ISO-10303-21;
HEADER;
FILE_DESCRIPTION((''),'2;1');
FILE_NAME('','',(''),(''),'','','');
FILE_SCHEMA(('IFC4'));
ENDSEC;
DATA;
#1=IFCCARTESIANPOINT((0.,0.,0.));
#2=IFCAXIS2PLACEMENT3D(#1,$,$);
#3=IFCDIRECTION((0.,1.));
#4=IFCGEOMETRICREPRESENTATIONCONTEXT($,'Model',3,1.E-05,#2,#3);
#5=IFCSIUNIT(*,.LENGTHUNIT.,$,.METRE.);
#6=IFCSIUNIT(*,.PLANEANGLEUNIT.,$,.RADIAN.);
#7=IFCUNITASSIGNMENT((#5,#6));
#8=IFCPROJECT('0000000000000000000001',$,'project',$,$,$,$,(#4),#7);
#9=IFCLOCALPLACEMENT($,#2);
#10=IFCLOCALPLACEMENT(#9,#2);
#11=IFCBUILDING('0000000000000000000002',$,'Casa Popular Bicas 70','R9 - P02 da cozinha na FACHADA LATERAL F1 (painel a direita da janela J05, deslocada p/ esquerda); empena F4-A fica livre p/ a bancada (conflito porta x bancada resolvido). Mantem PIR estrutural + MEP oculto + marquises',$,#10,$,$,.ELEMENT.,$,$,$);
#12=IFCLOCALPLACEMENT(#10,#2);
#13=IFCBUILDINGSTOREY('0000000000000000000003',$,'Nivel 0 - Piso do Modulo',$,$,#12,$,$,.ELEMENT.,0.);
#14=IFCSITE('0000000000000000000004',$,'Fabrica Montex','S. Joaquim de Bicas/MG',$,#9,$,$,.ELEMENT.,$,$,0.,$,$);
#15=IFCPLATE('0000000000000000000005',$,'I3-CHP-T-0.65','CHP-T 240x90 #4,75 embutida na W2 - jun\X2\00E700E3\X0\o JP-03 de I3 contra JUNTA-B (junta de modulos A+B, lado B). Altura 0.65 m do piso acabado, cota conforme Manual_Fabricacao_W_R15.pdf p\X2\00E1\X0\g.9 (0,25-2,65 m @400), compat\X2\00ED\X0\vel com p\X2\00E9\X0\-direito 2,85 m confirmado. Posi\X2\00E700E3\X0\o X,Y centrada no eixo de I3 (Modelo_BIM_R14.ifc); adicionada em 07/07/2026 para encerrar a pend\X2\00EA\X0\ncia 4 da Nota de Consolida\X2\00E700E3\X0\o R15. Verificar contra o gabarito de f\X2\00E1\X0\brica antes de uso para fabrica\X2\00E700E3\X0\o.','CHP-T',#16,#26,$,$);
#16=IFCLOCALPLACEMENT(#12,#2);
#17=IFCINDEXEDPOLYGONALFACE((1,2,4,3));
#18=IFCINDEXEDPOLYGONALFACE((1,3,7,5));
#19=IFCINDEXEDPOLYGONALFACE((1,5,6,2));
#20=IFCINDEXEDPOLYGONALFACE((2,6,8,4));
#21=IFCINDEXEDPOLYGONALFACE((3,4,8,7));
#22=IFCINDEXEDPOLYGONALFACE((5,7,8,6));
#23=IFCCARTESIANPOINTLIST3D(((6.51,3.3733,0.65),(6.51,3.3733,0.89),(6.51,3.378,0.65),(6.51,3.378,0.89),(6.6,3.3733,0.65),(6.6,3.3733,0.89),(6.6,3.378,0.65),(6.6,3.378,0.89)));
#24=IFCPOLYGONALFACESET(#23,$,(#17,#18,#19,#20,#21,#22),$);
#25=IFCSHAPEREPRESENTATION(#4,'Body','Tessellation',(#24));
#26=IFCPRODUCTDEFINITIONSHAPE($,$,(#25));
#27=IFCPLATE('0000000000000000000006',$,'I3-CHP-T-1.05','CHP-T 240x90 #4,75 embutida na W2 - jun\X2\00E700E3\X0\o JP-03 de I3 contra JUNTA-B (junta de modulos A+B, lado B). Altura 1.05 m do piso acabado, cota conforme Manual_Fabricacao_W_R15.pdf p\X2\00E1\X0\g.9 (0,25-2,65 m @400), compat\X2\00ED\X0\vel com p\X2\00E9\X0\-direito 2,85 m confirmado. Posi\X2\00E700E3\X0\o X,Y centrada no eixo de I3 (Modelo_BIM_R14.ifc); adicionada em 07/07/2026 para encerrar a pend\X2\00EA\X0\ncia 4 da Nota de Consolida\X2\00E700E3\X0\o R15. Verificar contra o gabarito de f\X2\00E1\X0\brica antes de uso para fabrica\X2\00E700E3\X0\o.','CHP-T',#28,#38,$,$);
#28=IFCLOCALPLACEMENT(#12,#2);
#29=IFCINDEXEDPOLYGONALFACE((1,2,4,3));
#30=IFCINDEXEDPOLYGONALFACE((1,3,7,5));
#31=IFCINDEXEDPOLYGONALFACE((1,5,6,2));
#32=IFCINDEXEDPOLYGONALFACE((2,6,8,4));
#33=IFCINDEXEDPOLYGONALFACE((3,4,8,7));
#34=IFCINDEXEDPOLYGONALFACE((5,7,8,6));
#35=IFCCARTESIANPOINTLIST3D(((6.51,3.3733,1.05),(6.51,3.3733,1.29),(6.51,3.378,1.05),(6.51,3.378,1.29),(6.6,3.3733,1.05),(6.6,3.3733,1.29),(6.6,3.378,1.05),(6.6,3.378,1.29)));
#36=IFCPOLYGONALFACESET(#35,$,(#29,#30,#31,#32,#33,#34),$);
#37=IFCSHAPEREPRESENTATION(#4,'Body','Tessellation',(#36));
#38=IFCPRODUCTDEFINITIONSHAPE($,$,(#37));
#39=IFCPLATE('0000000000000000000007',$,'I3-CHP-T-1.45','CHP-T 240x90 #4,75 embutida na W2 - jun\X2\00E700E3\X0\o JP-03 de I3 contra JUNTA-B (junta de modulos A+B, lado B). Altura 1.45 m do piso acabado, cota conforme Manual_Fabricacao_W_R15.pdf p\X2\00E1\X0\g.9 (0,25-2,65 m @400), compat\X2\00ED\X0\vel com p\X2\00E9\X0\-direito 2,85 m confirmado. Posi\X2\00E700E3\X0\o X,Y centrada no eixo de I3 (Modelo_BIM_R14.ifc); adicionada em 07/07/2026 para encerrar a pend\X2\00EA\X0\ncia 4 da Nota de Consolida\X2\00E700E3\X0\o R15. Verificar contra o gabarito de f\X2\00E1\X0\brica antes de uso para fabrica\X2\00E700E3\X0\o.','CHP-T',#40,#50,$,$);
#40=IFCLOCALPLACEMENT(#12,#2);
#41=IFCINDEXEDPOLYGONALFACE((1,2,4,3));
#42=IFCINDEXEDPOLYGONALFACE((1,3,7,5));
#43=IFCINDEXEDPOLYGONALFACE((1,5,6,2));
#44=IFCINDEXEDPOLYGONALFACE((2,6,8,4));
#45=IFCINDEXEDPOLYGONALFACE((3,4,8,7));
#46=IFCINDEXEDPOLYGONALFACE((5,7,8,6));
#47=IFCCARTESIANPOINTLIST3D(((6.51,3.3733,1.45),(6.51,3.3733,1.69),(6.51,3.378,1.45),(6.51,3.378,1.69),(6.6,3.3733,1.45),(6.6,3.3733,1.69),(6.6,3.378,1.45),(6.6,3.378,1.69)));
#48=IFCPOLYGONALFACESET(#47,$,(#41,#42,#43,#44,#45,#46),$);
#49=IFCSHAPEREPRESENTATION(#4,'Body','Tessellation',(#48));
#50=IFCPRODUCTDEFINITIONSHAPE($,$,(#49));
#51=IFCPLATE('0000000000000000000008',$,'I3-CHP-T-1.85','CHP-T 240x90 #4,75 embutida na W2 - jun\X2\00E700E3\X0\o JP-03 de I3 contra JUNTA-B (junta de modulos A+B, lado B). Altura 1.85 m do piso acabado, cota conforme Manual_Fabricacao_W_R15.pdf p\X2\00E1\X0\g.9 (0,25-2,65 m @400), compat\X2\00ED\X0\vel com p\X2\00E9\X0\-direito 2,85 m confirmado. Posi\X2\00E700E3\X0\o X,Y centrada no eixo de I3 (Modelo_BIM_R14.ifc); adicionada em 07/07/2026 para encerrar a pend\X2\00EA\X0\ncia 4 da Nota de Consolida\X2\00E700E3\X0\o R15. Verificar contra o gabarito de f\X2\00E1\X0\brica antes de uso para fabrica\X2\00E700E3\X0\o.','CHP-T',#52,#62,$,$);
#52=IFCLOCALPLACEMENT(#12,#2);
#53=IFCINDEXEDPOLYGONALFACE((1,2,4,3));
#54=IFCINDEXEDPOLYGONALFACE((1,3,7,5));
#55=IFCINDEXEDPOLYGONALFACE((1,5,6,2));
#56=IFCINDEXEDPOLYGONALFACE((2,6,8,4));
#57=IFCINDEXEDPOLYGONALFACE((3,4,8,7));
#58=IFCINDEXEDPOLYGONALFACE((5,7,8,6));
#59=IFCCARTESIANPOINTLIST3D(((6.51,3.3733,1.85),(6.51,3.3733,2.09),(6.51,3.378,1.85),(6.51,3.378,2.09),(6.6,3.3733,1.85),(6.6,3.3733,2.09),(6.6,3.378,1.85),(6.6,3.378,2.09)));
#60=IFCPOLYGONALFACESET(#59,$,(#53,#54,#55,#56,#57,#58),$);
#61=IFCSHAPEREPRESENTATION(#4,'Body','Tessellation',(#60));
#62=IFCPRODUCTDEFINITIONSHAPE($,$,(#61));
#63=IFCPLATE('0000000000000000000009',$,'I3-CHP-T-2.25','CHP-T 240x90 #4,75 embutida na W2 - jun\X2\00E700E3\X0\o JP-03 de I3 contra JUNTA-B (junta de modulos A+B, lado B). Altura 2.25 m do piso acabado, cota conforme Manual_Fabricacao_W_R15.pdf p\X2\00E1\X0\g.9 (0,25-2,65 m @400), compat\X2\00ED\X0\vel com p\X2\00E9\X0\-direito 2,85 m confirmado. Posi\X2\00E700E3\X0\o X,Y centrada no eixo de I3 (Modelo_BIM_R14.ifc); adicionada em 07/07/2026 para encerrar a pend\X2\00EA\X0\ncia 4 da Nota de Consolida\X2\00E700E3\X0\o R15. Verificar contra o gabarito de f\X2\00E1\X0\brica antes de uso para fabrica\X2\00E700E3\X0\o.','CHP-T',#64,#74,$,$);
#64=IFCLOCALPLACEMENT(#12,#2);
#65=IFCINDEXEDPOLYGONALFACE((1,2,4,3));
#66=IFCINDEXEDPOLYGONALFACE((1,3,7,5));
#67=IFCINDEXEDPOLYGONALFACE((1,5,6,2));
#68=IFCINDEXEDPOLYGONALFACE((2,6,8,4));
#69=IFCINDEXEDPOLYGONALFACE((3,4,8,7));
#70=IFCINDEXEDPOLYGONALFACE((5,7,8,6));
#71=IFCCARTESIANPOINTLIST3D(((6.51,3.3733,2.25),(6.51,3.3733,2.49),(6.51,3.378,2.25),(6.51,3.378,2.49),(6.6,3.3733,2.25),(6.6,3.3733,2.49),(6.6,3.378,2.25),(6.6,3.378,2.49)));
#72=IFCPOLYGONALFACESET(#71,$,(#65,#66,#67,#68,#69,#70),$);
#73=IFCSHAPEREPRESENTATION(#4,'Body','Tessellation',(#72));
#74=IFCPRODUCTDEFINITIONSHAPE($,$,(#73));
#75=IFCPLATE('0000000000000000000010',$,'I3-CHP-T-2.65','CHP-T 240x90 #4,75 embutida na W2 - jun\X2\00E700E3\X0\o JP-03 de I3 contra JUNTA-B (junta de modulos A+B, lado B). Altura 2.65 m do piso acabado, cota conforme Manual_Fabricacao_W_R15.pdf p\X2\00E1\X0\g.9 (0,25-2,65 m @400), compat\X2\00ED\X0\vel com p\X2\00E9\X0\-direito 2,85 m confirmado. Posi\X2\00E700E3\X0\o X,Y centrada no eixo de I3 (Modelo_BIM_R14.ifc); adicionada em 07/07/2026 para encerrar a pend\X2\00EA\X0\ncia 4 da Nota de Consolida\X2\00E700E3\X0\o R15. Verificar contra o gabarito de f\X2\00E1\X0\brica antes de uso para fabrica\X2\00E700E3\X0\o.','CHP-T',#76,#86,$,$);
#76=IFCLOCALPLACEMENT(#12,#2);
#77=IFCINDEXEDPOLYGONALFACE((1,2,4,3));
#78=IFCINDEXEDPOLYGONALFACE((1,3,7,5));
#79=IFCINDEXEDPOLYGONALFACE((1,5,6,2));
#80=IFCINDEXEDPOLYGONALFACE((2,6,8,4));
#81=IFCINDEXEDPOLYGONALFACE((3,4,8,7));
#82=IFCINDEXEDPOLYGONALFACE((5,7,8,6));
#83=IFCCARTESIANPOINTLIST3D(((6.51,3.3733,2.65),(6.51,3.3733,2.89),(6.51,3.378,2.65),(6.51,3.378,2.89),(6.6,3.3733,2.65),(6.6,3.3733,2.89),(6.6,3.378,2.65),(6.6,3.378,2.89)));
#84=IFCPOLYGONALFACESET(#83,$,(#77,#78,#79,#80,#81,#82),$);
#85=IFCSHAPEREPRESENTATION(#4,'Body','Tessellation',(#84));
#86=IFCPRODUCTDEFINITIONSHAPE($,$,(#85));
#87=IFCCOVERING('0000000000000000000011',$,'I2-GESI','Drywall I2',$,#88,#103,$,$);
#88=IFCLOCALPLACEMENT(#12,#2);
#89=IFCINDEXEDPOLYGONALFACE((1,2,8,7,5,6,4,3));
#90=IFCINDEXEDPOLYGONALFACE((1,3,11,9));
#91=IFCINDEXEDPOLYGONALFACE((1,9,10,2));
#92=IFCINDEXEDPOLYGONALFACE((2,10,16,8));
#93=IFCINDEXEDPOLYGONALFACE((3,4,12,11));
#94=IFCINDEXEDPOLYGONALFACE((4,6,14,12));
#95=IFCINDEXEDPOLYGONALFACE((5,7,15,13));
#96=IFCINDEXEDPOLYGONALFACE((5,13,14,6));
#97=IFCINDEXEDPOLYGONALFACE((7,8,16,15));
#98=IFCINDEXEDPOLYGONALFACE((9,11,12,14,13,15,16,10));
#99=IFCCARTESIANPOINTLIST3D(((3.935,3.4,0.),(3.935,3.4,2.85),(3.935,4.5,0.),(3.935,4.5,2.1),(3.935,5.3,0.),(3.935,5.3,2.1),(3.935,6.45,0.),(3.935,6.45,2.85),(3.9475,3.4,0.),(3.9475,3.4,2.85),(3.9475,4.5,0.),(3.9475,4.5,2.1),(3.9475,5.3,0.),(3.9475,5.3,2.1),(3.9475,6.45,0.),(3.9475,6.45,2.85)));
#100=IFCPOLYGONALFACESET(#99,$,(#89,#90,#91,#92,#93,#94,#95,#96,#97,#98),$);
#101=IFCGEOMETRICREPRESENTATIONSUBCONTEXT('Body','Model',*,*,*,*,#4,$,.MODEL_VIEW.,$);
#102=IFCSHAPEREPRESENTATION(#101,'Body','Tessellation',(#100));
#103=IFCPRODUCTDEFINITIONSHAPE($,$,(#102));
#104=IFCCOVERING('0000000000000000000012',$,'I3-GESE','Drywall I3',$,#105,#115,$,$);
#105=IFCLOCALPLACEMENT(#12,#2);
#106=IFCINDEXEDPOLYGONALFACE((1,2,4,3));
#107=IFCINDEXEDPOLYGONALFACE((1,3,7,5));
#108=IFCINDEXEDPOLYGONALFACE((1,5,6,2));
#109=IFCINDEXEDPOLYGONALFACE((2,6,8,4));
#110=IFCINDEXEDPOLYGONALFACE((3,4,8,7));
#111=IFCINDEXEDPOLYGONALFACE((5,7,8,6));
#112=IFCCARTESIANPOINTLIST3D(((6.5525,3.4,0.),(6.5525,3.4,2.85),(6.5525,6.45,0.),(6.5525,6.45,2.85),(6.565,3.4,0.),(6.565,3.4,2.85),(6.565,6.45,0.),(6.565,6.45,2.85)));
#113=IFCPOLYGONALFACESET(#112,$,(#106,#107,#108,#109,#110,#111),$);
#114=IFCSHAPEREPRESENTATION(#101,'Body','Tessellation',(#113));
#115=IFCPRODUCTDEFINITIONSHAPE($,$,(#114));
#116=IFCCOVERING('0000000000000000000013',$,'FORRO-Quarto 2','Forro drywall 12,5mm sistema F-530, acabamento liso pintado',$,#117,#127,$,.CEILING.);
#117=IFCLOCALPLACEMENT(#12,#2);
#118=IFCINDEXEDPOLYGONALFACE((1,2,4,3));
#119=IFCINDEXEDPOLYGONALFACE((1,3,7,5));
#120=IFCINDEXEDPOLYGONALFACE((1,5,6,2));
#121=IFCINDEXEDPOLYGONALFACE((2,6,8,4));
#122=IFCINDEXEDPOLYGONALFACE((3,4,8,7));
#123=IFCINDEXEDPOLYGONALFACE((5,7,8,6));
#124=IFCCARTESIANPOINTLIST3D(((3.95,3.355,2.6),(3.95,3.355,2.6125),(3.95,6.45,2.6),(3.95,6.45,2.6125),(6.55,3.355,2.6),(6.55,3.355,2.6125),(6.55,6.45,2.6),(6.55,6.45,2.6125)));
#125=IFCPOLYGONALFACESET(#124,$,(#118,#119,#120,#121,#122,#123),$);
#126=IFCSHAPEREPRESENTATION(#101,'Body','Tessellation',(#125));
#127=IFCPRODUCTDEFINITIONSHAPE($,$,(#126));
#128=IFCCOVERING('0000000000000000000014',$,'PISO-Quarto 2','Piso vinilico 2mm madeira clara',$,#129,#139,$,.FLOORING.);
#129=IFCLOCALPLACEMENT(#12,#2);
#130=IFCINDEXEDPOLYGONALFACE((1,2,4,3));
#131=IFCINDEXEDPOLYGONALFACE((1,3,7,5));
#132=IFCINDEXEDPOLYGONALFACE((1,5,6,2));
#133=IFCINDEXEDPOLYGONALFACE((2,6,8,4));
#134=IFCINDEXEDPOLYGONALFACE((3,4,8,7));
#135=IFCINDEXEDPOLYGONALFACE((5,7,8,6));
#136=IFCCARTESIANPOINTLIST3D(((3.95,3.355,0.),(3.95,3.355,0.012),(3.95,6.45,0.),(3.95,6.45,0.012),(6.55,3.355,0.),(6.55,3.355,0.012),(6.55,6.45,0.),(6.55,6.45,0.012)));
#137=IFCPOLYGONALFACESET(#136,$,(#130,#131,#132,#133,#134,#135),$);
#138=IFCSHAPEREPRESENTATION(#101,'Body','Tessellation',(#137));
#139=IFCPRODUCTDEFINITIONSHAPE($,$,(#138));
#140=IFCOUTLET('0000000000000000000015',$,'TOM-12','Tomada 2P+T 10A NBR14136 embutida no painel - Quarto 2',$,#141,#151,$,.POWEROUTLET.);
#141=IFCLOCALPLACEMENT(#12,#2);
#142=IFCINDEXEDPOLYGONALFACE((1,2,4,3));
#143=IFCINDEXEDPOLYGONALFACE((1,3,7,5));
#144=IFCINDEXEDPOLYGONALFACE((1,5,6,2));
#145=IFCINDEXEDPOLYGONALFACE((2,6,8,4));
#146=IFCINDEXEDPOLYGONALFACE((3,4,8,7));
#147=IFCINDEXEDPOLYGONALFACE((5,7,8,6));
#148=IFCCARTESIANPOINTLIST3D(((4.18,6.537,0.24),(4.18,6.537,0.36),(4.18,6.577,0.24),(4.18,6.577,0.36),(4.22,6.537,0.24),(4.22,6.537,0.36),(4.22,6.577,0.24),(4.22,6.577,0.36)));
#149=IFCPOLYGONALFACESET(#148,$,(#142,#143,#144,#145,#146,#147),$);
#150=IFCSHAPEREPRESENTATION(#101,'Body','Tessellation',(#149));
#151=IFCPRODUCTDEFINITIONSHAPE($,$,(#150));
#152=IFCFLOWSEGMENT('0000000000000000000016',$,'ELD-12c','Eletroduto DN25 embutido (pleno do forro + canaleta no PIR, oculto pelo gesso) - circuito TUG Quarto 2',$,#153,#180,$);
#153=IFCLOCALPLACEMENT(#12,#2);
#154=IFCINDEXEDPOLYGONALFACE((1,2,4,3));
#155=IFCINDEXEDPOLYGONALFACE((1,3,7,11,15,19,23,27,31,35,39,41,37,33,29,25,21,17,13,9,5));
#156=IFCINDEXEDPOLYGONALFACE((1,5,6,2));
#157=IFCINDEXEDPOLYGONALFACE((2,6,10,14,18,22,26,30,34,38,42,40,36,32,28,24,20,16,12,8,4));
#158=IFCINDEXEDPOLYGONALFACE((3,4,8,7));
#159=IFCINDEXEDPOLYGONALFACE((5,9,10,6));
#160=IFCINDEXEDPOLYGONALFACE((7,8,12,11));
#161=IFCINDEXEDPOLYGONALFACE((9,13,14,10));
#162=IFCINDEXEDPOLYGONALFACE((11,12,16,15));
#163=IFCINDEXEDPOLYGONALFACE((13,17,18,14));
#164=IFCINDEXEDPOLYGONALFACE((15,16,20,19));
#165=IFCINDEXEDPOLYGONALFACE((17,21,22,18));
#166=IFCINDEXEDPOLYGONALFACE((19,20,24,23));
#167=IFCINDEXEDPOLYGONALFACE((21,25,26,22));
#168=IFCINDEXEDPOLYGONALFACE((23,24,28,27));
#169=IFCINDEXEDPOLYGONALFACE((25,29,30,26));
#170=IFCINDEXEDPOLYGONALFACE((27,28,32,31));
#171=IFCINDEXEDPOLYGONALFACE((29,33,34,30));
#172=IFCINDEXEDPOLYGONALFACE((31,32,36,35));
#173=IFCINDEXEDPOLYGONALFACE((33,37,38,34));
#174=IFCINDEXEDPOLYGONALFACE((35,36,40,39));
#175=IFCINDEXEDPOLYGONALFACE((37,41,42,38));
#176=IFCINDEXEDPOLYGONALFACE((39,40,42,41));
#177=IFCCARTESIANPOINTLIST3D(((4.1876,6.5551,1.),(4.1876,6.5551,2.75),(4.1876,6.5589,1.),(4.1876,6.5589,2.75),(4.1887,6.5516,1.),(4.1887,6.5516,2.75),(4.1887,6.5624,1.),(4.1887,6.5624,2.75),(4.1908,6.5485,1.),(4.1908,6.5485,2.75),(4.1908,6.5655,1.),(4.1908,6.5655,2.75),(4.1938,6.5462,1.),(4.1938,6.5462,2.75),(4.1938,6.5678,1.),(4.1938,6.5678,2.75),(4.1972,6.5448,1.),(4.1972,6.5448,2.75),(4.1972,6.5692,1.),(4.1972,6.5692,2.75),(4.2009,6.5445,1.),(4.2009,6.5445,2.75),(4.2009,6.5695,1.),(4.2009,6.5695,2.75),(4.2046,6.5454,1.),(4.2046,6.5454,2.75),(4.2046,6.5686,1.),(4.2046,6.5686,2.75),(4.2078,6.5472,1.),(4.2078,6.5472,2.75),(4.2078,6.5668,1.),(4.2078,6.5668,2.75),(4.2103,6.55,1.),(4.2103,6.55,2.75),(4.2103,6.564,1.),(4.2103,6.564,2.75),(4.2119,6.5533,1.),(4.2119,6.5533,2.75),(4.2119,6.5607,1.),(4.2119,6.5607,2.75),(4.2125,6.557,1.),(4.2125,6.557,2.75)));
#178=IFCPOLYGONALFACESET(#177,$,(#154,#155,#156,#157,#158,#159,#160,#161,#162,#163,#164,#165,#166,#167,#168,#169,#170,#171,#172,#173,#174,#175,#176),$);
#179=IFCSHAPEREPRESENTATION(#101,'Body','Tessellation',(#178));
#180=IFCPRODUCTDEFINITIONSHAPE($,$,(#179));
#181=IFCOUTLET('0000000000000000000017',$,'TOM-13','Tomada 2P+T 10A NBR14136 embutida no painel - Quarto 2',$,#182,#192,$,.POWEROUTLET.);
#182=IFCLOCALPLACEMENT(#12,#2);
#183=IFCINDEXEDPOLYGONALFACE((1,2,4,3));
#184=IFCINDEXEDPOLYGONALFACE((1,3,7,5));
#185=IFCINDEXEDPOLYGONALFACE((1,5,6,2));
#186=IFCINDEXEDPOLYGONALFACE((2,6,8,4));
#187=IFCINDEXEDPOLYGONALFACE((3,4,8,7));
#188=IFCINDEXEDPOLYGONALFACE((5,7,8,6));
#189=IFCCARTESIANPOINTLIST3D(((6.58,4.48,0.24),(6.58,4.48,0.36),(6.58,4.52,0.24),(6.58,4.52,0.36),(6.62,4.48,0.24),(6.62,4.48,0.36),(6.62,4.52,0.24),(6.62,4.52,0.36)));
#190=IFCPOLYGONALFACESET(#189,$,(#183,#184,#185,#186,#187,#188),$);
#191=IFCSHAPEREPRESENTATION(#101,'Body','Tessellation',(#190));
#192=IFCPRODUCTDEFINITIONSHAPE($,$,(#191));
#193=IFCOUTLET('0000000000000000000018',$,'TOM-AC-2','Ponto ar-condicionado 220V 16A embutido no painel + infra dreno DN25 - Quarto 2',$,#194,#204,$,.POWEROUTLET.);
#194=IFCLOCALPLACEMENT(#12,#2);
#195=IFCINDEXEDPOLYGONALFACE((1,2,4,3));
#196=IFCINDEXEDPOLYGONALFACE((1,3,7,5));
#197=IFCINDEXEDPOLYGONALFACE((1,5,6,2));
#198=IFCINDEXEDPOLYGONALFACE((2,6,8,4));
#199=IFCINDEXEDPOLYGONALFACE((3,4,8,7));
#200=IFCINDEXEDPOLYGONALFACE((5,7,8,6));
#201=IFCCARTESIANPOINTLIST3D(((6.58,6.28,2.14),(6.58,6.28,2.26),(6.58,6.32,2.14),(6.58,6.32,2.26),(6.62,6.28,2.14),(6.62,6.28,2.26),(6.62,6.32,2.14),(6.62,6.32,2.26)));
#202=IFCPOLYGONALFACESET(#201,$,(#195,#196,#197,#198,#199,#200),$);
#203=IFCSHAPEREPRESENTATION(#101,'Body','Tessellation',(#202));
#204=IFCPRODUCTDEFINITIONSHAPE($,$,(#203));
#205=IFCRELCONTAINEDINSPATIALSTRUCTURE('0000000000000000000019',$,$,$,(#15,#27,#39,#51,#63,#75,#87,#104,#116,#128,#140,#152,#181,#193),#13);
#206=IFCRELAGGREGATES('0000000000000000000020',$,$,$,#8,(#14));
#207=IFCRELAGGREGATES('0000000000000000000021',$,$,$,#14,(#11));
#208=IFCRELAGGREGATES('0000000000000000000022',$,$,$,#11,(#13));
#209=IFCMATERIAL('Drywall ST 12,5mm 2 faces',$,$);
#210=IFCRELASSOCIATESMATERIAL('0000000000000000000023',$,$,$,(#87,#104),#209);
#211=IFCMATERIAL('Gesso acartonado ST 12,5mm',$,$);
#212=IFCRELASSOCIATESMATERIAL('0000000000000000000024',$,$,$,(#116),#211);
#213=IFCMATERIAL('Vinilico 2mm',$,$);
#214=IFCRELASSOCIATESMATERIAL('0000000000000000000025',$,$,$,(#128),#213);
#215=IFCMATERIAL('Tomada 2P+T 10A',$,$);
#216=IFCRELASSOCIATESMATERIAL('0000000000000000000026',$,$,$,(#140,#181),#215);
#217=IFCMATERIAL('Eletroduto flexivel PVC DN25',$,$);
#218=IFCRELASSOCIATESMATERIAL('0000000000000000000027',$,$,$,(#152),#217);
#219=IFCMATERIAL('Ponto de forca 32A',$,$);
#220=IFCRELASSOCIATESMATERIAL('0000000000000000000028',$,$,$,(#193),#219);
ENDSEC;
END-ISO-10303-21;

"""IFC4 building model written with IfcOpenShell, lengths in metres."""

from ifc_helpers import new_model, si_unit, direction, frame, frame_2d, origin, origin_with_axes, origin_2d, place, context, subcontext, project, spatial, rectangle, circle, extrude, material, element, save


model = new_model("IFC4")

# Units and contexts
model_context = context("Model", 3, precision=1e-05, world=origin(), true_north=direction((0.0, 1.0)))
body_context = subcontext(model_context, "Body", "Model", "MODEL_VIEW")
ifc_project = project(units=[si_unit("LENGTHUNIT", "METRE"), si_unit("PLANEANGLEUNIT", "RADIAN")], contexts=[model_context])

# Site, building, storey
site_placement = place(None, origin())
site = spatial("IfcSite", under=ifc_project, at=site_placement, Name="Fabrica Montex", Description="S. Joaquim de Bicas/MG", CompositionType="ELEMENT", RefElevation=0.0)
building_placement = place(site_placement, origin())
building = spatial("IfcBuilding", under=site, at=building_placement, Name="Casa Popular Bicas 70", Description="R9 - P02 da cozinha na FACHADA LATERAL F1 (painel a direita da janela J05, deslocada p/ esquerda); empena F4-A fica livre p/ a bancada (conflito porta x bancada resolvido). Mantem PIR estrutural + MEP oculto + marquises", CompositionType="ELEMENT")
storey_placement = place(building_placement, origin())
storey = spatial("IfcBuildingStorey", under=building, at=storey_placement, Name="Nivel 0 - Piso do Modulo", CompositionType="ELEMENT", Elevation=0.0)

# Plates
for number, where, z_axis, x_axis, name, description in (
    (1, (6.555, 3.3756, 0.65), (0.0, 0.0, 1.0), (1.0, 0.0, 0.0), "I3-CHP-T-0.65", "CHP-T 240x90 #4,75 embutida na W2 - junção JP-03 de I3 contra JUNTA-B (junta de modulos A+B, lado B). Altura 0.65 m do piso acabado, cota conforme Manual_Fabricacao_W_R15.pdf pág.9 (0,25-2,65 m @400), compatível com pé-direito 2,85 m confirmado. Posição X,Y centrada no eixo de I3 (Modelo_BIM_R14.ifc); adicionada em 07/07/2026 para encerrar a pendência 4 da Nota de Consolidação R15. Verificar contra o gabarito de fábrica antes de uso para fabricação."),
    (2, (6.555, 3.3756, 1.05), (0.0, 0.0, 1.0), (1.0, 0.0, 0.0), "I3-CHP-T-1.05", "CHP-T 240x90 #4,75 embutida na W2 - junção JP-03 de I3 contra JUNTA-B (junta de modulos A+B, lado B). Altura 1.05 m do piso acabado, cota conforme Manual_Fabricacao_W_R15.pdf pág.9 (0,25-2,65 m @400), compatível com pé-direito 2,85 m confirmado. Posição X,Y centrada no eixo de I3 (Modelo_BIM_R14.ifc); adicionada em 07/07/2026 para encerrar a pendência 4 da Nota de Consolidação R15. Verificar contra o gabarito de fábrica antes de uso para fabricação."),
    (3, (6.555, 3.3756, 1.45), (0.0, 0.0, 1.0), (1.0, 0.0, 0.0), "I3-CHP-T-1.45", "CHP-T 240x90 #4,75 embutida na W2 - junção JP-03 de I3 contra JUNTA-B (junta de modulos A+B, lado B). Altura 1.45 m do piso acabado, cota conforme Manual_Fabricacao_W_R15.pdf pág.9 (0,25-2,65 m @400), compatível com pé-direito 2,85 m confirmado. Posição X,Y centrada no eixo de I3 (Modelo_BIM_R14.ifc); adicionada em 07/07/2026 para encerrar a pendência 4 da Nota de Consolidação R15. Verificar contra o gabarito de fábrica antes de uso para fabricação."),
    (4, (6.555, 3.3756, 1.85), (0.0, 0.0, 1.0), (1.0, 0.0, 0.0), "I3-CHP-T-1.85", "CHP-T 240x90 #4,75 embutida na W2 - junção JP-03 de I3 contra JUNTA-B (junta de modulos A+B, lado B). Altura 1.85 m do piso acabado, cota conforme Manual_Fabricacao_W_R15.pdf pág.9 (0,25-2,65 m @400), compatível com pé-direito 2,85 m confirmado. Posição X,Y centrada no eixo de I3 (Modelo_BIM_R14.ifc); adicionada em 07/07/2026 para encerrar a pendência 4 da Nota de Consolidação R15. Verificar contra o gabarito de fábrica antes de uso para fabricação."),
    (5, (6.555, 3.3756, 2.25), (0.0, 0.0, 1.0), (1.0, 0.0, 0.0), "I3-CHP-T-2.25", "CHP-T 240x90 #4,75 embutida na W2 - junção JP-03 de I3 contra JUNTA-B (junta de modulos A+B, lado B). Altura 2.25 m do piso acabado, cota conforme Manual_Fabricacao_W_R15.pdf pág.9 (0,25-2,65 m @400), compatível com pé-direito 2,85 m confirmado. Posição X,Y centrada no eixo de I3 (Modelo_BIM_R14.ifc); adicionada em 07/07/2026 para encerrar a pendência 4 da Nota de Consolidação R15. Verificar contra o gabarito de fábrica antes de uso para fabricação."),
    (6, (6.555, 3.3756, 2.65), (0.0, 0.0, 1.0), (1.0, 0.0, 0.0), "I3-CHP-T-2.65", "CHP-T 240x90 #4,75 embutida na W2 - junção JP-03 de I3 contra JUNTA-B (junta de modulos A+B, lado B). Altura 2.65 m do piso acabado, cota conforme Manual_Fabricacao_W_R15.pdf pág.9 (0,25-2,65 m @400), compatível com pé-direito 2,85 m confirmado. Posição X,Y centrada no eixo de I3 (Modelo_BIM_R14.ifc); adicionada em 07/07/2026 para encerrar a pendência 4 da Nota de Consolidação R15. Verificar contra o gabarito de fábrica antes de uso para fabricação."),
):
    element("IfcPlate", number, at=place(storey_placement, frame(where, z_axis=z_axis, x_axis=x_axis)), inside=storey, Name=name, Description=description, ObjectType="CHP-T", context=model_context, shape_type="SweptSolid", body=[
        extrude(rectangle(XDim=0.09, YDim=0.0047, at=origin_2d()), origin_with_axes(), (0.0, 0.0, 1.0), 0.24),
    ])

# Covering, opening
ifc_material_1 = material(Name="Drywall ST 12,5mm 2 faces")
covering_1_placement = place(storey_placement, frame((3.9412, 3.4, 0.0), x_axis=(0.0, 1.0, 0.0)))
covering_1 = element("IfcCovering", 7, at=covering_1_placement, inside=storey, material=ifc_material_1, Name="I2-GESI", Description="Drywall I2", context=body_context, shape_type="SweptSolid", body=[
    extrude(rectangle(XDim=3.05, YDim=0.0125, at=frame_2d((1.525, 0.0))), origin(), (0.0, 0.0, 1.0), 2.85),
])
opening_1_placement = place(storey_placement, frame((3.9412, 4.9, 0.0)))
element("IfcOpeningElement", 8, at=opening_1_placement, cuts=covering_1, PredefinedType="OPENING", context=body_context, shape_type="SweptSolid", body=[
    extrude(rectangle(XDim=0.0425, YDim=0.8, at=origin_2d()), origin(), (0.0, 0.0, 1.0), 2.1),
])

# Coverings
covering_2_placement = place(storey_placement, frame((6.5587, 3.4, 0.0), x_axis=(0.0, 1.0, 0.0)))
element("IfcCovering", 9, at=covering_2_placement, inside=storey, material=ifc_material_1, Name="I3-GESE", Description="Drywall I3", context=body_context, shape_type="SweptSolid", body=[
    extrude(rectangle(XDim=3.05, YDim=0.0125, at=frame_2d((1.525, 0.0))), origin(), (0.0, 0.0, 1.0), 2.85),
])
ifc_material_2 = material(Name="Gesso acartonado ST 12,5mm")
covering_3_placement = place(storey_placement, frame((3.95, 3.355, 2.6)))
element("IfcCovering", 10, at=covering_3_placement, inside=storey, material=ifc_material_2, Name="FORRO-Quarto 2", Description="Forro drywall 12,5mm sistema F-530, acabamento liso pintado", PredefinedType="CEILING", context=body_context, shape_type="SweptSolid", body=[
    extrude(rectangle(XDim=2.6, YDim=3.095, at=frame_2d((1.3, 1.5475))), origin(), (0.0, 0.0, 1.0), 0.0125),
])
ifc_material_3 = material(Name="Vinilico 2mm")
covering_4_placement = place(storey_placement, frame((3.95, 3.355, 0.0)))
element("IfcCovering", 11, at=covering_4_placement, inside=storey, material=ifc_material_3, Name="PISO-Quarto 2", Description="Piso vinilico 2mm madeira clara", PredefinedType="FLOORING", context=body_context, shape_type="SweptSolid", body=[
    extrude(rectangle(XDim=2.6, YDim=3.095, at=frame_2d((1.3, 1.5475))), origin(), (0.0, 0.0, 1.0), 0.012),
])

# Outlet
ifc_material_4 = material(Name="Tomada 2P+T 10A")
outlet_1_placement = place(storey_placement, frame((4.18, 6.537, 0.24)))
element("IfcOutlet", 12, at=outlet_1_placement, inside=storey, material=ifc_material_4, Name="TOM-12", Description="Tomada 2P+T 10A NBR14136 embutida no painel - Quarto 2", PredefinedType="POWEROUTLET", context=body_context, shape_type="SweptSolid", body=[
    extrude(rectangle(XDim=0.04, YDim=0.04, at=frame_2d((0.02, 0.02))), origin(), (0.0, 0.0, 1.0), 0.12),
])

# Flow segment
ifc_material_5 = material(Name="Eletroduto flexivel PVC DN25")
flow_segment_1_placement = place(storey_placement, frame((4.2, 6.557, 2.75), z_axis=(0.0, 0.0, -1.0), x_axis=(1.0, 0.0, 0.0)))
element("IfcFlowSegment", 13, at=flow_segment_1_placement, inside=storey, material=ifc_material_5, Name="ELD-12c", Description="Eletroduto DN25 embutido (pleno do forro + canaleta no PIR, oculto pelo gesso) - circuito TUG Quarto 2", context=body_context, shape_type="SweptSolid", body=[
    extrude(circle(Radius=0.0125, at=origin_2d()), origin(), (0.0, 0.0, 1.0), 1.75),
])

# Outlets
outlet_2_placement = place(storey_placement, frame((6.58, 4.48, 0.24)))
element("IfcOutlet", 14, at=outlet_2_placement, inside=storey, material=ifc_material_4, Name="TOM-13", Description="Tomada 2P+T 10A NBR14136 embutida no painel - Quarto 2", PredefinedType="POWEROUTLET", context=body_context, shape_type="SweptSolid", body=[
    extrude(rectangle(XDim=0.04, YDim=0.04, at=frame_2d((0.02, 0.02))), origin(), (0.0, 0.0, 1.0), 0.12),
])
ifc_material_6 = material(Name="Ponto de forca 32A")
outlet_3_placement = place(storey_placement, frame((6.58, 6.28, 2.14)))
element("IfcOutlet", 15, at=outlet_3_placement, inside=storey, material=ifc_material_6, Name="TOM-AC-2", Description="Ponto ar-condicionado 220V 16A embutido no painel + infra dreno DN25 - Quarto 2", PredefinedType="POWEROUTLET", context=body_context, shape_type="SweptSolid", body=[
    extrude(rectangle(XDim=0.04, YDim=0.04, at=frame_2d((0.02, 0.02))), origin(), (0.0, 0.0, 1.0), 0.12),
])

save(model, "model.ifc")
